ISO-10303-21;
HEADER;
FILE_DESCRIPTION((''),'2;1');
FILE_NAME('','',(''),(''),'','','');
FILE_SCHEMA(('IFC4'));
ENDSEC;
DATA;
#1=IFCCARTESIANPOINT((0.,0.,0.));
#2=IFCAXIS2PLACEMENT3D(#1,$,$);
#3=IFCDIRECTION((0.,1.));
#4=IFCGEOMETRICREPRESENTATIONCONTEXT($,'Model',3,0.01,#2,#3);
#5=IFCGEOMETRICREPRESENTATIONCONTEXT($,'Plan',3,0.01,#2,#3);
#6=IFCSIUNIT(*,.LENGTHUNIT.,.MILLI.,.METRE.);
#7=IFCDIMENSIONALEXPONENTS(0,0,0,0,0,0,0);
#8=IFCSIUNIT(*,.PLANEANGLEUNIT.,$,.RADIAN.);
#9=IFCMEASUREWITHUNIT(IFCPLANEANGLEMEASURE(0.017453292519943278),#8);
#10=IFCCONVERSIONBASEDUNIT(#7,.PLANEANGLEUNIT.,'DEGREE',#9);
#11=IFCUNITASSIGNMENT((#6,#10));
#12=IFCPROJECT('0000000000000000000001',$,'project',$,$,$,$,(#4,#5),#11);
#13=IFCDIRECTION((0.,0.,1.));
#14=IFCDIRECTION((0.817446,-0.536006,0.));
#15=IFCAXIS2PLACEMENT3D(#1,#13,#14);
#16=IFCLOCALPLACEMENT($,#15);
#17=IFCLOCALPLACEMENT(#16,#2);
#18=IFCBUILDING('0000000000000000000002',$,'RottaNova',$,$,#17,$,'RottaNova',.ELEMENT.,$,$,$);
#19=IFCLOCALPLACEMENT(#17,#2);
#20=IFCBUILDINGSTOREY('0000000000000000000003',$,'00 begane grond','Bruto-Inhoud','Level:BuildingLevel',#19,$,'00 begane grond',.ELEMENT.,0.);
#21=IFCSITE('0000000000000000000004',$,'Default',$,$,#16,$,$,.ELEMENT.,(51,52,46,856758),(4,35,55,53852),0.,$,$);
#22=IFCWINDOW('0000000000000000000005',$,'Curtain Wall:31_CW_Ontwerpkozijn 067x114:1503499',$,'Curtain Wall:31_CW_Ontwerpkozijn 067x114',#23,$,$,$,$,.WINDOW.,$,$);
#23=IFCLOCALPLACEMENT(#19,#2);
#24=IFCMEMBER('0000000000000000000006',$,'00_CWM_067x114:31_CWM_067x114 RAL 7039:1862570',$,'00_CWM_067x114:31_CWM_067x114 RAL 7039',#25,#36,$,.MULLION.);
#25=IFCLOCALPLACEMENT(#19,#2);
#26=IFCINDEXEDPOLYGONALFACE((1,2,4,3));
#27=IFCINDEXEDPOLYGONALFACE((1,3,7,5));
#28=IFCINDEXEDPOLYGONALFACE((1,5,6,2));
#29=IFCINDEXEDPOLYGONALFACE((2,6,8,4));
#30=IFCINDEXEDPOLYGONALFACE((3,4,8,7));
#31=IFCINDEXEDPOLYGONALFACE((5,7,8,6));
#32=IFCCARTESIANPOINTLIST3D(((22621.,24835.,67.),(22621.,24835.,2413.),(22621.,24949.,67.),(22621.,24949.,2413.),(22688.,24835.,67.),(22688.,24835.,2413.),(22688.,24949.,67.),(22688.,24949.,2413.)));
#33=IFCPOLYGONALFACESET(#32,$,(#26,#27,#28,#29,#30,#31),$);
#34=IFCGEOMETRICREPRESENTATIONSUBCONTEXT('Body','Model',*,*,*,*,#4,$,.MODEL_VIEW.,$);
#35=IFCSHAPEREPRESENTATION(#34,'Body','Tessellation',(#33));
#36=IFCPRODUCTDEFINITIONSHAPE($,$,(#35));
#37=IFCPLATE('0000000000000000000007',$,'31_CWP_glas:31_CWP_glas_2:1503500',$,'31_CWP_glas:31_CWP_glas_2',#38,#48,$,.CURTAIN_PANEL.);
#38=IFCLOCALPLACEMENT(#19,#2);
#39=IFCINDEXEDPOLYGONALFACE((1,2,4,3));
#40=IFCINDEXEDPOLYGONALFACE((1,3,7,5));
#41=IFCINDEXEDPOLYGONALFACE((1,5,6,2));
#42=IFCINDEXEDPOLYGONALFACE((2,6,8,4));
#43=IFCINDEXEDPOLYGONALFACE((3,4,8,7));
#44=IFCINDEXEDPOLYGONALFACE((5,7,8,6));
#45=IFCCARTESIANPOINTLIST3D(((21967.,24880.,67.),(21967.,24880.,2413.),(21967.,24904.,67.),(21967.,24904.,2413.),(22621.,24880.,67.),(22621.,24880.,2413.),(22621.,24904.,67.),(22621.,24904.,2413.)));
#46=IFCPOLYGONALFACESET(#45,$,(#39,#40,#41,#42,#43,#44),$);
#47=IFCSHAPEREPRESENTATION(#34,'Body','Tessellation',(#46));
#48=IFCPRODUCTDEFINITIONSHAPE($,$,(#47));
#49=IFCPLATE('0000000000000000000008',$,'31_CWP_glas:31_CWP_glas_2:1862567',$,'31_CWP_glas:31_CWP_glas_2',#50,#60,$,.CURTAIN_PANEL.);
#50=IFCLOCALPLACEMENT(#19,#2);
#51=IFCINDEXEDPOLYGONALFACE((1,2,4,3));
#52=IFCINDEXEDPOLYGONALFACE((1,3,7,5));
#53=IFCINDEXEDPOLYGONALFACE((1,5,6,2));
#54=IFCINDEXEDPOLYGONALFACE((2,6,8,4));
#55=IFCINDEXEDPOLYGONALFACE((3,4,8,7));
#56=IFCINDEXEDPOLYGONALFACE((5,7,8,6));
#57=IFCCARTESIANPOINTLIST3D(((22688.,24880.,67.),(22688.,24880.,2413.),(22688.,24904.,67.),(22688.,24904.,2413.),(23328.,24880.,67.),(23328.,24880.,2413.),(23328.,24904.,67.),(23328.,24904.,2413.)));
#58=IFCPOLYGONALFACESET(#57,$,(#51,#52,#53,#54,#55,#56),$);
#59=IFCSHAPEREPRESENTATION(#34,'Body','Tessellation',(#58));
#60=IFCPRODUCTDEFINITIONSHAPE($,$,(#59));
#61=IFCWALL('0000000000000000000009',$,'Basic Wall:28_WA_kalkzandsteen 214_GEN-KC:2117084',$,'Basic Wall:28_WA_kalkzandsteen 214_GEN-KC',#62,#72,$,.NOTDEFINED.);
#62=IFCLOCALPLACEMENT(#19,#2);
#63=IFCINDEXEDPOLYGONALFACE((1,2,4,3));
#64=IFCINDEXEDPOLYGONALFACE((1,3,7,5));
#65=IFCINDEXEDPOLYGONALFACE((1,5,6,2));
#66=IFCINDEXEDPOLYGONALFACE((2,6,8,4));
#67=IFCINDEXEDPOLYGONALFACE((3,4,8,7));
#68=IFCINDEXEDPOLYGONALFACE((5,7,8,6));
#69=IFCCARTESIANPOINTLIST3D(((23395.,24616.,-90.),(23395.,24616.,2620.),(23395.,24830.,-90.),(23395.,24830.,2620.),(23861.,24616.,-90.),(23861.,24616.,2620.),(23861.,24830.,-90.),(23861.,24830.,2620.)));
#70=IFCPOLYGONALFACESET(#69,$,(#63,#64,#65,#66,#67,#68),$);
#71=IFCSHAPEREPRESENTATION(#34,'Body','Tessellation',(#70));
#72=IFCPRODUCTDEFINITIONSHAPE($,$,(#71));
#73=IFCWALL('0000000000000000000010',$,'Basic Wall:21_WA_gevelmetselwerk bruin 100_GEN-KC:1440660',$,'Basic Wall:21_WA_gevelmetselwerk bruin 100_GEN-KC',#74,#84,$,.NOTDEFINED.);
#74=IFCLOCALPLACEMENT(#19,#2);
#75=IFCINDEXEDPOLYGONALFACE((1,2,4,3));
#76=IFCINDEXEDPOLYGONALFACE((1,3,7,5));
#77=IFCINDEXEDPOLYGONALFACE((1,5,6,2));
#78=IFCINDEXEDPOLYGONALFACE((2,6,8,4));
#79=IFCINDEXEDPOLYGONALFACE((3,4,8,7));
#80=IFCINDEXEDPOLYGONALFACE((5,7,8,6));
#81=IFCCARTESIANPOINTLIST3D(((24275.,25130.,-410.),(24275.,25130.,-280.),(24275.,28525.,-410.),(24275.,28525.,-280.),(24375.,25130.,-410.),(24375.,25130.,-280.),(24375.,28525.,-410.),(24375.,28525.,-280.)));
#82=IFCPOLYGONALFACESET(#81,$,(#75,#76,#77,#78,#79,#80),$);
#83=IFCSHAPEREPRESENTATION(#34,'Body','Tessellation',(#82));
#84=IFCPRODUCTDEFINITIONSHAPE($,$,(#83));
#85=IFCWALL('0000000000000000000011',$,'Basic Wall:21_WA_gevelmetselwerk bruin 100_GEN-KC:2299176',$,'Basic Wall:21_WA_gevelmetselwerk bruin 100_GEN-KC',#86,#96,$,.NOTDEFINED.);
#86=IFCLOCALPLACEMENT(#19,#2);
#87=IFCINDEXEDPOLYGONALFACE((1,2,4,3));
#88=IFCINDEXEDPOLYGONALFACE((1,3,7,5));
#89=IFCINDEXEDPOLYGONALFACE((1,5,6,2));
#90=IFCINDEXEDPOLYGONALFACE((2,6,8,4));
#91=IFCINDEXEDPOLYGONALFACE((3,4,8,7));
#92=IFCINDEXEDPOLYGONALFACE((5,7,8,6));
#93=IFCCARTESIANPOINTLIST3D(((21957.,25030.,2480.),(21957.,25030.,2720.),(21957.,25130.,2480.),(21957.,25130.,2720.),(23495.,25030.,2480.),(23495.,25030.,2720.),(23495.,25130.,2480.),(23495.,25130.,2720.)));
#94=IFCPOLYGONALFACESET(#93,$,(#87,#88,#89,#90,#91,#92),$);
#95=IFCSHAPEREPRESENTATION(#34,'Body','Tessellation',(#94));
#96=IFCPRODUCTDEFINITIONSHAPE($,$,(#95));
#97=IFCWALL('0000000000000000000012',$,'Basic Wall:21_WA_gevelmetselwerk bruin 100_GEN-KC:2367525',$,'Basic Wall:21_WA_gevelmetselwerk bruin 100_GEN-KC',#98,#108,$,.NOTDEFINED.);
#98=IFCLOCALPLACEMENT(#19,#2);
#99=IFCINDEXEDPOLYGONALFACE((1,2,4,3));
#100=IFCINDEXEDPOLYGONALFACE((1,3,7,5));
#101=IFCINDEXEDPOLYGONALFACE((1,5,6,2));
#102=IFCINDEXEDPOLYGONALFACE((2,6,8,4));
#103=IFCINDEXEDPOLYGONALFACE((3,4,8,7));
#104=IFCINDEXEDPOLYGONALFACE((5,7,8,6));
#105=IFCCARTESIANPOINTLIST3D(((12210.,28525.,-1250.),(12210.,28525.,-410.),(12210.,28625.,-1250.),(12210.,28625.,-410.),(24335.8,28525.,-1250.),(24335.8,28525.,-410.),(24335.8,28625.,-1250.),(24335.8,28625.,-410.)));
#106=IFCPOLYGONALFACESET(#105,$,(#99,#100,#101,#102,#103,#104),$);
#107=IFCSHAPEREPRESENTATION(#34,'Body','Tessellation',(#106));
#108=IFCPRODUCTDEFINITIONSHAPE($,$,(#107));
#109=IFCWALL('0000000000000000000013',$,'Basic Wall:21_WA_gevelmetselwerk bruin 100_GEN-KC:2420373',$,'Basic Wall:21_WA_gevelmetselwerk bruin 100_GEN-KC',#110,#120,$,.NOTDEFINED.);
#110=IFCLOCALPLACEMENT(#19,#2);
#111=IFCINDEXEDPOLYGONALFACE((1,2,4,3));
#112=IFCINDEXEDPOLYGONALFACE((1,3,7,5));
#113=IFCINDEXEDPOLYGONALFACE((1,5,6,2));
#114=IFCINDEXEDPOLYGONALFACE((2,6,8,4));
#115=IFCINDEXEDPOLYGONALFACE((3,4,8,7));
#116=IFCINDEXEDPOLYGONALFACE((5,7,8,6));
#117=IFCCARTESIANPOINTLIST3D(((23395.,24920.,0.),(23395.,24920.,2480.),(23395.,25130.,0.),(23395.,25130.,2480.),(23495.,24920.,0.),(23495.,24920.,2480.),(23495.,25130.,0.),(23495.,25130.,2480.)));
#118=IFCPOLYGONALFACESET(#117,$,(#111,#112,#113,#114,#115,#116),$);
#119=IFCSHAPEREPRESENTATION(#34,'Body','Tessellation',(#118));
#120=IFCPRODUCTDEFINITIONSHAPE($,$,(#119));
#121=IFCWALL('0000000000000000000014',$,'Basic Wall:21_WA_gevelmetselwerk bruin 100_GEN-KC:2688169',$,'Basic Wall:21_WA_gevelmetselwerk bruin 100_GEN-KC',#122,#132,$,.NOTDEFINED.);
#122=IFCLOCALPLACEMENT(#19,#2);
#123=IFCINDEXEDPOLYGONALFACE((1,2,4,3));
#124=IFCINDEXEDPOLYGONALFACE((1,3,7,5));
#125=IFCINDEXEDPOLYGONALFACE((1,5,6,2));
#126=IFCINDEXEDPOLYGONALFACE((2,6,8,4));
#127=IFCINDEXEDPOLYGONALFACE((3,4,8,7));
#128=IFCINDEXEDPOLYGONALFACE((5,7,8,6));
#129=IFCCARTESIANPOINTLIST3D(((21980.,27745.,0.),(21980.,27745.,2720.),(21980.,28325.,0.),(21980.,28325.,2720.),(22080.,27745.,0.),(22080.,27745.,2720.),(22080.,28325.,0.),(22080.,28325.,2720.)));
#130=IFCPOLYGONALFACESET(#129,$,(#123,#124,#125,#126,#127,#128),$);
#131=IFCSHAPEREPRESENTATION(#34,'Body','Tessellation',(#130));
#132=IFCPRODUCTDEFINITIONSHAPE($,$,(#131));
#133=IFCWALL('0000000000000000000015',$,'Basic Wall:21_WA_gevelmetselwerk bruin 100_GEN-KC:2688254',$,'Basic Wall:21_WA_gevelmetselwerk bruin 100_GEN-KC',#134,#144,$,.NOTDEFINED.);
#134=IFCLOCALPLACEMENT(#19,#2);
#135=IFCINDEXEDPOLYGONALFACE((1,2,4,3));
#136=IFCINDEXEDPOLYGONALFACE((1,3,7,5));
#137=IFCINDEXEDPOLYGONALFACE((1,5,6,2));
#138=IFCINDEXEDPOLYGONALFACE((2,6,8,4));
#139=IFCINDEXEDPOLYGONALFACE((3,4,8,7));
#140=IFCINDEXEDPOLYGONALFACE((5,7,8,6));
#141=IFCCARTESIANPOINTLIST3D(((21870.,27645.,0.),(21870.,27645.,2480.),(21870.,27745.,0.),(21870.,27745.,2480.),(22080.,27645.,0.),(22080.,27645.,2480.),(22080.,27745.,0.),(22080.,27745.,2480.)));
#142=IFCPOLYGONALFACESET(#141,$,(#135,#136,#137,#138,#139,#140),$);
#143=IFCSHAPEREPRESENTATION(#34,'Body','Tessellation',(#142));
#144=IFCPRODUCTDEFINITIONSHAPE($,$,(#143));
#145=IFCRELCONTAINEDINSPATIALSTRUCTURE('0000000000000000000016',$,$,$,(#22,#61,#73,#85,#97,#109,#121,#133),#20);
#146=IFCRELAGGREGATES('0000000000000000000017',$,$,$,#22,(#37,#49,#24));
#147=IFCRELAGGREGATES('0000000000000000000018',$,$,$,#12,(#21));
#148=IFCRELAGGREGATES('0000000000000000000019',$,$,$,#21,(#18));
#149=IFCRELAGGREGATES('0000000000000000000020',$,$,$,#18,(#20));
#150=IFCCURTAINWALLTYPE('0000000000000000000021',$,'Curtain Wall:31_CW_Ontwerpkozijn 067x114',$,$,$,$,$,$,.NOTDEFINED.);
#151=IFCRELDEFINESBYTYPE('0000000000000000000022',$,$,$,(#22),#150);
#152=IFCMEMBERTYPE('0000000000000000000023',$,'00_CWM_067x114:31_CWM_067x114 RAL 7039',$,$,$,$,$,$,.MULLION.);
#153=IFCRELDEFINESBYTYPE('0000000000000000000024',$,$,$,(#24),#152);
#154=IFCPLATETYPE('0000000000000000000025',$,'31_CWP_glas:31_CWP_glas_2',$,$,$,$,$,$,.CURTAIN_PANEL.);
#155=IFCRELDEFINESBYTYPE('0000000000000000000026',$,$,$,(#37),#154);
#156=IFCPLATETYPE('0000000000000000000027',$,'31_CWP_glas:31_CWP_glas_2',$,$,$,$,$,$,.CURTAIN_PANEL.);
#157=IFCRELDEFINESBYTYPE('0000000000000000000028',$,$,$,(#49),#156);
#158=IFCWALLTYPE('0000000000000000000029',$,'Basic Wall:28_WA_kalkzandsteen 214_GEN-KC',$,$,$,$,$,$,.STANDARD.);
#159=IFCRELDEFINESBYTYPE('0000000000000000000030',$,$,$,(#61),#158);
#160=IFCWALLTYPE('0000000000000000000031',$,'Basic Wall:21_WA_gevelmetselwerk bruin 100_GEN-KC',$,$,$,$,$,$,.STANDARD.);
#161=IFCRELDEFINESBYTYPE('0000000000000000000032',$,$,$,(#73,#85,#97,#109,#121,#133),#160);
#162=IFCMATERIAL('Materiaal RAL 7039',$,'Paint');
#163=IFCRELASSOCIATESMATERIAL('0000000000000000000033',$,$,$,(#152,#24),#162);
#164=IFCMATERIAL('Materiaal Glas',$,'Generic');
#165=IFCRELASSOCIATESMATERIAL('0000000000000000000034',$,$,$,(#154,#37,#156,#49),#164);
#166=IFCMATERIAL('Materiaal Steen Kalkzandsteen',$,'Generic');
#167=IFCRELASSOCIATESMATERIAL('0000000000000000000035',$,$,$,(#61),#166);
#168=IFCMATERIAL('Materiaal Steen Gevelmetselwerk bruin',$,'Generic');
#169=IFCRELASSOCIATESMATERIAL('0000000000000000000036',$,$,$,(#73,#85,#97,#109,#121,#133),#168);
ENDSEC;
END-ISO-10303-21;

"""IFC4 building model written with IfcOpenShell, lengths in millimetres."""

from ifc_helpers import new_model, entity, si_unit, converted_unit, direction, frame, origin, place, context, subcontext, project, spatial, indexed_curve, outline, extrude, source, transform, mapped, material, type_object, type_shapes, element, aggregate, save


model = new_model("IFC4")

# Units and contexts
model_context = context("Model", 3, precision=0.01, world=origin(), true_north=direction((0.0, 1.0)))
plan_context = context("Plan", 3, precision=0.01, world=origin(), true_north=direction((0.0, 1.0)))
body_context = subcontext(model_context, "Body", "Model", "MODEL_VIEW")
ifc_project = project(units=[si_unit("LENGTHUNIT", "METRE", prefix="MILLI"), converted_unit("PLANEANGLEUNIT", "DEGREE", entity("IfcPlaneAngleMeasure", 0.017453292519943278), si_unit("PLANEANGLEUNIT", "RADIAN"), dimensions=[0, 0, 0, 0, 0, 0, 0])], contexts=[model_context, plan_context])

# Site, building, storey
site_placement = place(None, frame((0.0, 0.0, 0.0), z_axis=(0.0, 0.0, 1.0), x_axis=(0.817446, -0.536006, 0.0)))
site = spatial("IfcSite", under=ifc_project, at=site_placement, Name="Default", CompositionType="ELEMENT", RefLatitude=(51, 52, 46, 856758), RefLongitude=(4, 35, 55, 53852), RefElevation=0.0)
building_placement = place(site_placement, origin())
building = spatial("IfcBuilding", under=site, at=building_placement, Name="RottaNova", LongName="RottaNova", CompositionType="ELEMENT")
storey_placement = place(building_placement, origin())
storey = spatial("IfcBuildingStorey", under=building, at=storey_placement, Name="00 begane grond", Description="Bruto-Inhoud", ObjectType="Level:BuildingLevel", LongName="00 begane grond", CompositionType="ELEMENT", Elevation=0.0)

# Shared definitions
curtain_wall_type = type_object("IfcCurtainWallType", Name="Curtain Wall:31_CW_Ontwerpkozijn 067x114", PredefinedType="NOTDEFINED")
ifc_material_1 = material(Name="Materiaal RAL 7039", Category="Paint")

# Window, member, plates
window_1_placement = place(storey_placement, origin())
window_1 = element("IfcWindow", 1, at=window_1_placement, inside=storey, type_object=curtain_wall_type, Name="Curtain Wall:31_CW_Ontwerpkozijn 067x114:1503499", ObjectType="Curtain Wall:31_CW_Ontwerpkozijn 067x114", PredefinedType="WINDOW")
member_type_1 = type_object("IfcMemberType", Name="00_CWM_067x114:31_CWM_067x114 RAL 7039", PredefinedType="MULLION", material=ifc_material_1)
shared_shape_1 = source(origin(), body_context, "Body", "SweptSolid", [
    extrude(outline(indexed_curve([(-33.5, -57.0), (33.5, -57.0), (33.5, 57.0), (-33.5, 57.0), (-33.5, -57.0)], self_intersect=False)), frame((0.0, -57.0, -2346.0), z_axis=(0.0, 0.0, 1.0), x_axis=(-1.0, 0.0, 0.0)), (0.0, 0.0, 1.0), 2346.0),
])
type_shapes(member_type_1, [shared_shape_1])
member_1_placement = place(window_1_placement, frame((22654.5, 24835.0, 67.0), z_axis=(0.0, 0.0, -1.0), x_axis=(1.0, 0.0, 0.0)))
member_1 = element("IfcMember", 2, at=member_1_placement, type_object=member_type_1, material=ifc_material_1, Name="00_CWM_067x114:31_CWM_067x114 RAL 7039:1862570", ObjectType="00_CWM_067x114:31_CWM_067x114 RAL 7039", PredefinedType="MULLION", context=body_context, shape_type="MappedRepresentation", body=[
    mapped(shared_shape_1, transform((0.0, 0.0, 0.0), scale=1.0)),
])
ifc_material_2 = material(Name="Materiaal Glas", Category="Generic")
plate_type_1 = type_object("IfcPlateType", Name="31_CWP_glas:31_CWP_glas_2", PredefinedType="CURTAIN_PANEL", material=ifc_material_2)
shared_shape_2 = source(origin(), body_context, "Body", "SweptSolid", [
    extrude(outline(indexed_curve([(-12.0, -327.0), (12.0, -327.0), (12.0, 327.0), (-12.0, 327.0), (-12.0, -327.0)], self_intersect=False)), frame((0.0, 57.0, 0.0), z_axis=(0.0, 0.0, 1.0), x_axis=(0.0, 1.0, 0.0)), (0.0, 0.0, 1.0), 2346.0),
])
type_shapes(plate_type_1, [shared_shape_2])
plate_1_placement = place(window_1_placement, frame((22294.0, 24835.0, 67.0)))
plate_1 = element("IfcPlate", 3, at=plate_1_placement, type_object=plate_type_1, material=ifc_material_2, Name="31_CWP_glas:31_CWP_glas_2:1503500", ObjectType="31_CWP_glas:31_CWP_glas_2", PredefinedType="CURTAIN_PANEL", context=body_context, shape_type="MappedRepresentation", body=[
    mapped(shared_shape_2, transform((0.0, 0.0, 0.0), scale=1.0)),
])
plate_type_2 = type_object("IfcPlateType", Name="31_CWP_glas:31_CWP_glas_2", PredefinedType="CURTAIN_PANEL", material=ifc_material_2)
shared_shape_3 = source(origin(), body_context, "Body", "SweptSolid", [
    extrude(outline(indexed_curve([(-12.0, -320.0), (12.0, -320.0), (12.0, 320.0), (-12.0, 320.0), (-12.0, -320.0)], self_intersect=False)), frame((0.0, 57.0, 0.0), z_axis=(0.0, 0.0, 1.0), x_axis=(0.0, 1.0, 0.0)), (0.0, 0.0, 1.0), 2346.0),
])
type_shapes(plate_type_2, [shared_shape_3])
plate_2_placement = place(window_1_placement, frame((23008.0, 24835.0, 67.0)))
plate_2 = element("IfcPlate", 4, at=plate_2_placement, type_object=plate_type_2, material=ifc_material_2, Name="31_CWP_glas:31_CWP_glas_2:1862567", ObjectType="31_CWP_glas:31_CWP_glas_2", PredefinedType="CURTAIN_PANEL", context=body_context, shape_type="MappedRepresentation", body=[
    mapped(shared_shape_3, transform((0.0, 0.0, 0.0), scale=1.0)),
])
aggregate(window_1, [plate_1, plate_2, member_1])

# Walls
ifc_material_3 = material(Name="Materiaal Steen Kalkzandsteen", Category="Generic")
wall_type_1 = type_object("IfcWallType", Name="Basic Wall:28_WA_kalkzandsteen 214_GEN-KC", PredefinedType="STANDARD")
wall_1_placement = place(storey_placement, frame((23395.0, 24723.0, -90.0)))
element("IfcWall", 5, at=wall_1_placement, inside=storey, type_object=wall_type_1, material=ifc_material_3, Name="Basic Wall:28_WA_kalkzandsteen 214_GEN-KC:2117084", ObjectType="Basic Wall:28_WA_kalkzandsteen 214_GEN-KC", PredefinedType="NOTDEFINED", context=body_context, shape_type="SweptSolid", body=[
    extrude(outline(indexed_curve([(466.0, 107.0), (0.0, 107.0), (0.0, -107.0), (466.0, -107.0), (466.0, 107.0)], self_intersect=False)), origin(), (0.0, 0.0, 1.0), 2710.0),
])
ifc_material_4 = material(Name="Materiaal Steen Gevelmetselwerk bruin", Category="Generic")
wall_type_2 = type_object("IfcWallType", Name="Basic Wall:21_WA_gevelmetselwerk bruin 100_GEN-KC", PredefinedType="STANDARD")
wall_2_placement = place(storey_placement, frame((24325.0, 25130.0, -410.0), z_axis=(0.0, 0.0, 1.0), x_axis=(0.0, 1.0, 0.0)))
element("IfcWall", 6, at=wall_2_placement, inside=storey, type_object=wall_type_2, material=ifc_material_4, Name="Basic Wall:21_WA_gevelmetselwerk bruin 100_GEN-KC:1440660", ObjectType="Basic Wall:21_WA_gevelmetselwerk bruin 100_GEN-KC", PredefinedType="NOTDEFINED", context=body_context, shape_type="SweptSolid", body=[
    extrude(outline(indexed_curve([(3395.0, 50.0), (0.0, 50.0), (0.0, -50.0), (3395.0, -50.0), (3395.0, 50.0)], self_intersect=False)), origin(), (0.0, 0.0, 1.0), 130.0),
])
wall_3_placement = place(storey_placement, frame((23495.0, 25080.0, 2480.0), z_axis=(0.0, 0.0, 1.0), x_axis=(-1.0, 0.0, 0.0)))
element("IfcWall", 7, at=wall_3_placement, inside=storey, type_object=wall_type_2, material=ifc_material_4, Name="Basic Wall:21_WA_gevelmetselwerk bruin 100_GEN-KC:2299176", ObjectType="Basic Wall:21_WA_gevelmetselwerk bruin 100_GEN-KC", PredefinedType="NOTDEFINED", context=body_context, shape_type="SweptSolid", body=[
    extrude(outline(indexed_curve([(1538.0, 50.0), (0.0, 50.0), (0.0, -50.0), (1538.0, -50.0), (1538.0, 50.0)], self_intersect=False)), origin(), (0.0, 0.0, 1.0), 240.0),
])
wall_4_placement = place(storey_placement, frame((24335.8, 28575.0, -1250.0), z_axis=(0.0, 0.0, 1.0), x_axis=(-1.0, 0.0, 0.0)))
element("IfcWall", 8, at=wall_4_placement, inside=storey, type_object=wall_type_2, material=ifc_material_4, Name="Basic Wall:21_WA_gevelmetselwerk bruin 100_GEN-KC:2367525", ObjectType="Basic Wall:21_WA_gevelmetselwerk bruin 100_GEN-KC", PredefinedType="NOTDEFINED", context=body_context, shape_type="SweptSolid", body=[
    extrude(outline(indexed_curve([(12125.8, 50.0), (0.0, 50.0), (0.0, -50.0), (12125.8, -50.0), (12125.8, 50.0)], self_intersect=False)), origin(), (0.0, 0.0, 1.0), 840.0),
])
wall_5_placement = place(storey_placement, frame((23445.0, 24920.0, 0.0), z_axis=(0.0, 0.0, 1.0), x_axis=(0.0, 1.0, 0.0)))
element("IfcWall", 9, at=wall_5_placement, inside=storey, type_object=wall_type_2, material=ifc_material_4, Name="Basic Wall:21_WA_gevelmetselwerk bruin 100_GEN-KC:2420373", ObjectType="Basic Wall:21_WA_gevelmetselwerk bruin 100_GEN-KC", PredefinedType="NOTDEFINED", context=body_context, shape_type="SweptSolid", body=[
    extrude(outline(indexed_curve([(210.0, 50.0), (0.0, 50.0), (0.0, -50.0), (210.0, -50.0), (210.0, 50.0)], self_intersect=False)), origin(), (0.0, 0.0, 1.0), 2480.0),
])
wall_6_placement = place(storey_placement, frame((22030.0, 27745.0, 0.0), z_axis=(0.0, 0.0, 1.0), x_axis=(0.0, 1.0, 0.0)))
element("IfcWall", 10, at=wall_6_placement, inside=storey, type_object=wall_type_2, material=ifc_material_4, Name="Basic Wall:21_WA_gevelmetselwerk bruin 100_GEN-KC:2688169", ObjectType="Basic Wall:21_WA_gevelmetselwerk bruin 100_GEN-KC", PredefinedType="NOTDEFINED", context=body_context, shape_type="SweptSolid", body=[
    extrude(outline(indexed_curve([(580.0, 50.0), (0.0, 50.0), (0.0, -50.0), (580.0, -50.0), (580.0, 50.0)], self_intersect=False)), origin(), (0.0, 0.0, 1.0), 2720.0),
])
wall_7_placement = place(storey_placement, frame((21870.0, 27695.0, 0.0)))
element("IfcWall", 11, at=wall_7_placement, inside=storey, type_object=wall_type_2, material=ifc_material_4, Name="Basic Wall:21_WA_gevelmetselwerk bruin 100_GEN-KC:2688254", ObjectType="Basic Wall:21_WA_gevelmetselwerk bruin 100_GEN-KC", PredefinedType="NOTDEFINED", context=body_context, shape_type="SweptSolid", body=[
    extrude(outline(indexed_curve([(210.0, 50.0), (0.0, 50.0), (0.0, -50.0), (210.0, -50.0), (210.0, 50.0)], self_intersect=False)), origin(), (0.0, 0.0, 1.0), 2480.0),
])

save(model, "model.ifc")
